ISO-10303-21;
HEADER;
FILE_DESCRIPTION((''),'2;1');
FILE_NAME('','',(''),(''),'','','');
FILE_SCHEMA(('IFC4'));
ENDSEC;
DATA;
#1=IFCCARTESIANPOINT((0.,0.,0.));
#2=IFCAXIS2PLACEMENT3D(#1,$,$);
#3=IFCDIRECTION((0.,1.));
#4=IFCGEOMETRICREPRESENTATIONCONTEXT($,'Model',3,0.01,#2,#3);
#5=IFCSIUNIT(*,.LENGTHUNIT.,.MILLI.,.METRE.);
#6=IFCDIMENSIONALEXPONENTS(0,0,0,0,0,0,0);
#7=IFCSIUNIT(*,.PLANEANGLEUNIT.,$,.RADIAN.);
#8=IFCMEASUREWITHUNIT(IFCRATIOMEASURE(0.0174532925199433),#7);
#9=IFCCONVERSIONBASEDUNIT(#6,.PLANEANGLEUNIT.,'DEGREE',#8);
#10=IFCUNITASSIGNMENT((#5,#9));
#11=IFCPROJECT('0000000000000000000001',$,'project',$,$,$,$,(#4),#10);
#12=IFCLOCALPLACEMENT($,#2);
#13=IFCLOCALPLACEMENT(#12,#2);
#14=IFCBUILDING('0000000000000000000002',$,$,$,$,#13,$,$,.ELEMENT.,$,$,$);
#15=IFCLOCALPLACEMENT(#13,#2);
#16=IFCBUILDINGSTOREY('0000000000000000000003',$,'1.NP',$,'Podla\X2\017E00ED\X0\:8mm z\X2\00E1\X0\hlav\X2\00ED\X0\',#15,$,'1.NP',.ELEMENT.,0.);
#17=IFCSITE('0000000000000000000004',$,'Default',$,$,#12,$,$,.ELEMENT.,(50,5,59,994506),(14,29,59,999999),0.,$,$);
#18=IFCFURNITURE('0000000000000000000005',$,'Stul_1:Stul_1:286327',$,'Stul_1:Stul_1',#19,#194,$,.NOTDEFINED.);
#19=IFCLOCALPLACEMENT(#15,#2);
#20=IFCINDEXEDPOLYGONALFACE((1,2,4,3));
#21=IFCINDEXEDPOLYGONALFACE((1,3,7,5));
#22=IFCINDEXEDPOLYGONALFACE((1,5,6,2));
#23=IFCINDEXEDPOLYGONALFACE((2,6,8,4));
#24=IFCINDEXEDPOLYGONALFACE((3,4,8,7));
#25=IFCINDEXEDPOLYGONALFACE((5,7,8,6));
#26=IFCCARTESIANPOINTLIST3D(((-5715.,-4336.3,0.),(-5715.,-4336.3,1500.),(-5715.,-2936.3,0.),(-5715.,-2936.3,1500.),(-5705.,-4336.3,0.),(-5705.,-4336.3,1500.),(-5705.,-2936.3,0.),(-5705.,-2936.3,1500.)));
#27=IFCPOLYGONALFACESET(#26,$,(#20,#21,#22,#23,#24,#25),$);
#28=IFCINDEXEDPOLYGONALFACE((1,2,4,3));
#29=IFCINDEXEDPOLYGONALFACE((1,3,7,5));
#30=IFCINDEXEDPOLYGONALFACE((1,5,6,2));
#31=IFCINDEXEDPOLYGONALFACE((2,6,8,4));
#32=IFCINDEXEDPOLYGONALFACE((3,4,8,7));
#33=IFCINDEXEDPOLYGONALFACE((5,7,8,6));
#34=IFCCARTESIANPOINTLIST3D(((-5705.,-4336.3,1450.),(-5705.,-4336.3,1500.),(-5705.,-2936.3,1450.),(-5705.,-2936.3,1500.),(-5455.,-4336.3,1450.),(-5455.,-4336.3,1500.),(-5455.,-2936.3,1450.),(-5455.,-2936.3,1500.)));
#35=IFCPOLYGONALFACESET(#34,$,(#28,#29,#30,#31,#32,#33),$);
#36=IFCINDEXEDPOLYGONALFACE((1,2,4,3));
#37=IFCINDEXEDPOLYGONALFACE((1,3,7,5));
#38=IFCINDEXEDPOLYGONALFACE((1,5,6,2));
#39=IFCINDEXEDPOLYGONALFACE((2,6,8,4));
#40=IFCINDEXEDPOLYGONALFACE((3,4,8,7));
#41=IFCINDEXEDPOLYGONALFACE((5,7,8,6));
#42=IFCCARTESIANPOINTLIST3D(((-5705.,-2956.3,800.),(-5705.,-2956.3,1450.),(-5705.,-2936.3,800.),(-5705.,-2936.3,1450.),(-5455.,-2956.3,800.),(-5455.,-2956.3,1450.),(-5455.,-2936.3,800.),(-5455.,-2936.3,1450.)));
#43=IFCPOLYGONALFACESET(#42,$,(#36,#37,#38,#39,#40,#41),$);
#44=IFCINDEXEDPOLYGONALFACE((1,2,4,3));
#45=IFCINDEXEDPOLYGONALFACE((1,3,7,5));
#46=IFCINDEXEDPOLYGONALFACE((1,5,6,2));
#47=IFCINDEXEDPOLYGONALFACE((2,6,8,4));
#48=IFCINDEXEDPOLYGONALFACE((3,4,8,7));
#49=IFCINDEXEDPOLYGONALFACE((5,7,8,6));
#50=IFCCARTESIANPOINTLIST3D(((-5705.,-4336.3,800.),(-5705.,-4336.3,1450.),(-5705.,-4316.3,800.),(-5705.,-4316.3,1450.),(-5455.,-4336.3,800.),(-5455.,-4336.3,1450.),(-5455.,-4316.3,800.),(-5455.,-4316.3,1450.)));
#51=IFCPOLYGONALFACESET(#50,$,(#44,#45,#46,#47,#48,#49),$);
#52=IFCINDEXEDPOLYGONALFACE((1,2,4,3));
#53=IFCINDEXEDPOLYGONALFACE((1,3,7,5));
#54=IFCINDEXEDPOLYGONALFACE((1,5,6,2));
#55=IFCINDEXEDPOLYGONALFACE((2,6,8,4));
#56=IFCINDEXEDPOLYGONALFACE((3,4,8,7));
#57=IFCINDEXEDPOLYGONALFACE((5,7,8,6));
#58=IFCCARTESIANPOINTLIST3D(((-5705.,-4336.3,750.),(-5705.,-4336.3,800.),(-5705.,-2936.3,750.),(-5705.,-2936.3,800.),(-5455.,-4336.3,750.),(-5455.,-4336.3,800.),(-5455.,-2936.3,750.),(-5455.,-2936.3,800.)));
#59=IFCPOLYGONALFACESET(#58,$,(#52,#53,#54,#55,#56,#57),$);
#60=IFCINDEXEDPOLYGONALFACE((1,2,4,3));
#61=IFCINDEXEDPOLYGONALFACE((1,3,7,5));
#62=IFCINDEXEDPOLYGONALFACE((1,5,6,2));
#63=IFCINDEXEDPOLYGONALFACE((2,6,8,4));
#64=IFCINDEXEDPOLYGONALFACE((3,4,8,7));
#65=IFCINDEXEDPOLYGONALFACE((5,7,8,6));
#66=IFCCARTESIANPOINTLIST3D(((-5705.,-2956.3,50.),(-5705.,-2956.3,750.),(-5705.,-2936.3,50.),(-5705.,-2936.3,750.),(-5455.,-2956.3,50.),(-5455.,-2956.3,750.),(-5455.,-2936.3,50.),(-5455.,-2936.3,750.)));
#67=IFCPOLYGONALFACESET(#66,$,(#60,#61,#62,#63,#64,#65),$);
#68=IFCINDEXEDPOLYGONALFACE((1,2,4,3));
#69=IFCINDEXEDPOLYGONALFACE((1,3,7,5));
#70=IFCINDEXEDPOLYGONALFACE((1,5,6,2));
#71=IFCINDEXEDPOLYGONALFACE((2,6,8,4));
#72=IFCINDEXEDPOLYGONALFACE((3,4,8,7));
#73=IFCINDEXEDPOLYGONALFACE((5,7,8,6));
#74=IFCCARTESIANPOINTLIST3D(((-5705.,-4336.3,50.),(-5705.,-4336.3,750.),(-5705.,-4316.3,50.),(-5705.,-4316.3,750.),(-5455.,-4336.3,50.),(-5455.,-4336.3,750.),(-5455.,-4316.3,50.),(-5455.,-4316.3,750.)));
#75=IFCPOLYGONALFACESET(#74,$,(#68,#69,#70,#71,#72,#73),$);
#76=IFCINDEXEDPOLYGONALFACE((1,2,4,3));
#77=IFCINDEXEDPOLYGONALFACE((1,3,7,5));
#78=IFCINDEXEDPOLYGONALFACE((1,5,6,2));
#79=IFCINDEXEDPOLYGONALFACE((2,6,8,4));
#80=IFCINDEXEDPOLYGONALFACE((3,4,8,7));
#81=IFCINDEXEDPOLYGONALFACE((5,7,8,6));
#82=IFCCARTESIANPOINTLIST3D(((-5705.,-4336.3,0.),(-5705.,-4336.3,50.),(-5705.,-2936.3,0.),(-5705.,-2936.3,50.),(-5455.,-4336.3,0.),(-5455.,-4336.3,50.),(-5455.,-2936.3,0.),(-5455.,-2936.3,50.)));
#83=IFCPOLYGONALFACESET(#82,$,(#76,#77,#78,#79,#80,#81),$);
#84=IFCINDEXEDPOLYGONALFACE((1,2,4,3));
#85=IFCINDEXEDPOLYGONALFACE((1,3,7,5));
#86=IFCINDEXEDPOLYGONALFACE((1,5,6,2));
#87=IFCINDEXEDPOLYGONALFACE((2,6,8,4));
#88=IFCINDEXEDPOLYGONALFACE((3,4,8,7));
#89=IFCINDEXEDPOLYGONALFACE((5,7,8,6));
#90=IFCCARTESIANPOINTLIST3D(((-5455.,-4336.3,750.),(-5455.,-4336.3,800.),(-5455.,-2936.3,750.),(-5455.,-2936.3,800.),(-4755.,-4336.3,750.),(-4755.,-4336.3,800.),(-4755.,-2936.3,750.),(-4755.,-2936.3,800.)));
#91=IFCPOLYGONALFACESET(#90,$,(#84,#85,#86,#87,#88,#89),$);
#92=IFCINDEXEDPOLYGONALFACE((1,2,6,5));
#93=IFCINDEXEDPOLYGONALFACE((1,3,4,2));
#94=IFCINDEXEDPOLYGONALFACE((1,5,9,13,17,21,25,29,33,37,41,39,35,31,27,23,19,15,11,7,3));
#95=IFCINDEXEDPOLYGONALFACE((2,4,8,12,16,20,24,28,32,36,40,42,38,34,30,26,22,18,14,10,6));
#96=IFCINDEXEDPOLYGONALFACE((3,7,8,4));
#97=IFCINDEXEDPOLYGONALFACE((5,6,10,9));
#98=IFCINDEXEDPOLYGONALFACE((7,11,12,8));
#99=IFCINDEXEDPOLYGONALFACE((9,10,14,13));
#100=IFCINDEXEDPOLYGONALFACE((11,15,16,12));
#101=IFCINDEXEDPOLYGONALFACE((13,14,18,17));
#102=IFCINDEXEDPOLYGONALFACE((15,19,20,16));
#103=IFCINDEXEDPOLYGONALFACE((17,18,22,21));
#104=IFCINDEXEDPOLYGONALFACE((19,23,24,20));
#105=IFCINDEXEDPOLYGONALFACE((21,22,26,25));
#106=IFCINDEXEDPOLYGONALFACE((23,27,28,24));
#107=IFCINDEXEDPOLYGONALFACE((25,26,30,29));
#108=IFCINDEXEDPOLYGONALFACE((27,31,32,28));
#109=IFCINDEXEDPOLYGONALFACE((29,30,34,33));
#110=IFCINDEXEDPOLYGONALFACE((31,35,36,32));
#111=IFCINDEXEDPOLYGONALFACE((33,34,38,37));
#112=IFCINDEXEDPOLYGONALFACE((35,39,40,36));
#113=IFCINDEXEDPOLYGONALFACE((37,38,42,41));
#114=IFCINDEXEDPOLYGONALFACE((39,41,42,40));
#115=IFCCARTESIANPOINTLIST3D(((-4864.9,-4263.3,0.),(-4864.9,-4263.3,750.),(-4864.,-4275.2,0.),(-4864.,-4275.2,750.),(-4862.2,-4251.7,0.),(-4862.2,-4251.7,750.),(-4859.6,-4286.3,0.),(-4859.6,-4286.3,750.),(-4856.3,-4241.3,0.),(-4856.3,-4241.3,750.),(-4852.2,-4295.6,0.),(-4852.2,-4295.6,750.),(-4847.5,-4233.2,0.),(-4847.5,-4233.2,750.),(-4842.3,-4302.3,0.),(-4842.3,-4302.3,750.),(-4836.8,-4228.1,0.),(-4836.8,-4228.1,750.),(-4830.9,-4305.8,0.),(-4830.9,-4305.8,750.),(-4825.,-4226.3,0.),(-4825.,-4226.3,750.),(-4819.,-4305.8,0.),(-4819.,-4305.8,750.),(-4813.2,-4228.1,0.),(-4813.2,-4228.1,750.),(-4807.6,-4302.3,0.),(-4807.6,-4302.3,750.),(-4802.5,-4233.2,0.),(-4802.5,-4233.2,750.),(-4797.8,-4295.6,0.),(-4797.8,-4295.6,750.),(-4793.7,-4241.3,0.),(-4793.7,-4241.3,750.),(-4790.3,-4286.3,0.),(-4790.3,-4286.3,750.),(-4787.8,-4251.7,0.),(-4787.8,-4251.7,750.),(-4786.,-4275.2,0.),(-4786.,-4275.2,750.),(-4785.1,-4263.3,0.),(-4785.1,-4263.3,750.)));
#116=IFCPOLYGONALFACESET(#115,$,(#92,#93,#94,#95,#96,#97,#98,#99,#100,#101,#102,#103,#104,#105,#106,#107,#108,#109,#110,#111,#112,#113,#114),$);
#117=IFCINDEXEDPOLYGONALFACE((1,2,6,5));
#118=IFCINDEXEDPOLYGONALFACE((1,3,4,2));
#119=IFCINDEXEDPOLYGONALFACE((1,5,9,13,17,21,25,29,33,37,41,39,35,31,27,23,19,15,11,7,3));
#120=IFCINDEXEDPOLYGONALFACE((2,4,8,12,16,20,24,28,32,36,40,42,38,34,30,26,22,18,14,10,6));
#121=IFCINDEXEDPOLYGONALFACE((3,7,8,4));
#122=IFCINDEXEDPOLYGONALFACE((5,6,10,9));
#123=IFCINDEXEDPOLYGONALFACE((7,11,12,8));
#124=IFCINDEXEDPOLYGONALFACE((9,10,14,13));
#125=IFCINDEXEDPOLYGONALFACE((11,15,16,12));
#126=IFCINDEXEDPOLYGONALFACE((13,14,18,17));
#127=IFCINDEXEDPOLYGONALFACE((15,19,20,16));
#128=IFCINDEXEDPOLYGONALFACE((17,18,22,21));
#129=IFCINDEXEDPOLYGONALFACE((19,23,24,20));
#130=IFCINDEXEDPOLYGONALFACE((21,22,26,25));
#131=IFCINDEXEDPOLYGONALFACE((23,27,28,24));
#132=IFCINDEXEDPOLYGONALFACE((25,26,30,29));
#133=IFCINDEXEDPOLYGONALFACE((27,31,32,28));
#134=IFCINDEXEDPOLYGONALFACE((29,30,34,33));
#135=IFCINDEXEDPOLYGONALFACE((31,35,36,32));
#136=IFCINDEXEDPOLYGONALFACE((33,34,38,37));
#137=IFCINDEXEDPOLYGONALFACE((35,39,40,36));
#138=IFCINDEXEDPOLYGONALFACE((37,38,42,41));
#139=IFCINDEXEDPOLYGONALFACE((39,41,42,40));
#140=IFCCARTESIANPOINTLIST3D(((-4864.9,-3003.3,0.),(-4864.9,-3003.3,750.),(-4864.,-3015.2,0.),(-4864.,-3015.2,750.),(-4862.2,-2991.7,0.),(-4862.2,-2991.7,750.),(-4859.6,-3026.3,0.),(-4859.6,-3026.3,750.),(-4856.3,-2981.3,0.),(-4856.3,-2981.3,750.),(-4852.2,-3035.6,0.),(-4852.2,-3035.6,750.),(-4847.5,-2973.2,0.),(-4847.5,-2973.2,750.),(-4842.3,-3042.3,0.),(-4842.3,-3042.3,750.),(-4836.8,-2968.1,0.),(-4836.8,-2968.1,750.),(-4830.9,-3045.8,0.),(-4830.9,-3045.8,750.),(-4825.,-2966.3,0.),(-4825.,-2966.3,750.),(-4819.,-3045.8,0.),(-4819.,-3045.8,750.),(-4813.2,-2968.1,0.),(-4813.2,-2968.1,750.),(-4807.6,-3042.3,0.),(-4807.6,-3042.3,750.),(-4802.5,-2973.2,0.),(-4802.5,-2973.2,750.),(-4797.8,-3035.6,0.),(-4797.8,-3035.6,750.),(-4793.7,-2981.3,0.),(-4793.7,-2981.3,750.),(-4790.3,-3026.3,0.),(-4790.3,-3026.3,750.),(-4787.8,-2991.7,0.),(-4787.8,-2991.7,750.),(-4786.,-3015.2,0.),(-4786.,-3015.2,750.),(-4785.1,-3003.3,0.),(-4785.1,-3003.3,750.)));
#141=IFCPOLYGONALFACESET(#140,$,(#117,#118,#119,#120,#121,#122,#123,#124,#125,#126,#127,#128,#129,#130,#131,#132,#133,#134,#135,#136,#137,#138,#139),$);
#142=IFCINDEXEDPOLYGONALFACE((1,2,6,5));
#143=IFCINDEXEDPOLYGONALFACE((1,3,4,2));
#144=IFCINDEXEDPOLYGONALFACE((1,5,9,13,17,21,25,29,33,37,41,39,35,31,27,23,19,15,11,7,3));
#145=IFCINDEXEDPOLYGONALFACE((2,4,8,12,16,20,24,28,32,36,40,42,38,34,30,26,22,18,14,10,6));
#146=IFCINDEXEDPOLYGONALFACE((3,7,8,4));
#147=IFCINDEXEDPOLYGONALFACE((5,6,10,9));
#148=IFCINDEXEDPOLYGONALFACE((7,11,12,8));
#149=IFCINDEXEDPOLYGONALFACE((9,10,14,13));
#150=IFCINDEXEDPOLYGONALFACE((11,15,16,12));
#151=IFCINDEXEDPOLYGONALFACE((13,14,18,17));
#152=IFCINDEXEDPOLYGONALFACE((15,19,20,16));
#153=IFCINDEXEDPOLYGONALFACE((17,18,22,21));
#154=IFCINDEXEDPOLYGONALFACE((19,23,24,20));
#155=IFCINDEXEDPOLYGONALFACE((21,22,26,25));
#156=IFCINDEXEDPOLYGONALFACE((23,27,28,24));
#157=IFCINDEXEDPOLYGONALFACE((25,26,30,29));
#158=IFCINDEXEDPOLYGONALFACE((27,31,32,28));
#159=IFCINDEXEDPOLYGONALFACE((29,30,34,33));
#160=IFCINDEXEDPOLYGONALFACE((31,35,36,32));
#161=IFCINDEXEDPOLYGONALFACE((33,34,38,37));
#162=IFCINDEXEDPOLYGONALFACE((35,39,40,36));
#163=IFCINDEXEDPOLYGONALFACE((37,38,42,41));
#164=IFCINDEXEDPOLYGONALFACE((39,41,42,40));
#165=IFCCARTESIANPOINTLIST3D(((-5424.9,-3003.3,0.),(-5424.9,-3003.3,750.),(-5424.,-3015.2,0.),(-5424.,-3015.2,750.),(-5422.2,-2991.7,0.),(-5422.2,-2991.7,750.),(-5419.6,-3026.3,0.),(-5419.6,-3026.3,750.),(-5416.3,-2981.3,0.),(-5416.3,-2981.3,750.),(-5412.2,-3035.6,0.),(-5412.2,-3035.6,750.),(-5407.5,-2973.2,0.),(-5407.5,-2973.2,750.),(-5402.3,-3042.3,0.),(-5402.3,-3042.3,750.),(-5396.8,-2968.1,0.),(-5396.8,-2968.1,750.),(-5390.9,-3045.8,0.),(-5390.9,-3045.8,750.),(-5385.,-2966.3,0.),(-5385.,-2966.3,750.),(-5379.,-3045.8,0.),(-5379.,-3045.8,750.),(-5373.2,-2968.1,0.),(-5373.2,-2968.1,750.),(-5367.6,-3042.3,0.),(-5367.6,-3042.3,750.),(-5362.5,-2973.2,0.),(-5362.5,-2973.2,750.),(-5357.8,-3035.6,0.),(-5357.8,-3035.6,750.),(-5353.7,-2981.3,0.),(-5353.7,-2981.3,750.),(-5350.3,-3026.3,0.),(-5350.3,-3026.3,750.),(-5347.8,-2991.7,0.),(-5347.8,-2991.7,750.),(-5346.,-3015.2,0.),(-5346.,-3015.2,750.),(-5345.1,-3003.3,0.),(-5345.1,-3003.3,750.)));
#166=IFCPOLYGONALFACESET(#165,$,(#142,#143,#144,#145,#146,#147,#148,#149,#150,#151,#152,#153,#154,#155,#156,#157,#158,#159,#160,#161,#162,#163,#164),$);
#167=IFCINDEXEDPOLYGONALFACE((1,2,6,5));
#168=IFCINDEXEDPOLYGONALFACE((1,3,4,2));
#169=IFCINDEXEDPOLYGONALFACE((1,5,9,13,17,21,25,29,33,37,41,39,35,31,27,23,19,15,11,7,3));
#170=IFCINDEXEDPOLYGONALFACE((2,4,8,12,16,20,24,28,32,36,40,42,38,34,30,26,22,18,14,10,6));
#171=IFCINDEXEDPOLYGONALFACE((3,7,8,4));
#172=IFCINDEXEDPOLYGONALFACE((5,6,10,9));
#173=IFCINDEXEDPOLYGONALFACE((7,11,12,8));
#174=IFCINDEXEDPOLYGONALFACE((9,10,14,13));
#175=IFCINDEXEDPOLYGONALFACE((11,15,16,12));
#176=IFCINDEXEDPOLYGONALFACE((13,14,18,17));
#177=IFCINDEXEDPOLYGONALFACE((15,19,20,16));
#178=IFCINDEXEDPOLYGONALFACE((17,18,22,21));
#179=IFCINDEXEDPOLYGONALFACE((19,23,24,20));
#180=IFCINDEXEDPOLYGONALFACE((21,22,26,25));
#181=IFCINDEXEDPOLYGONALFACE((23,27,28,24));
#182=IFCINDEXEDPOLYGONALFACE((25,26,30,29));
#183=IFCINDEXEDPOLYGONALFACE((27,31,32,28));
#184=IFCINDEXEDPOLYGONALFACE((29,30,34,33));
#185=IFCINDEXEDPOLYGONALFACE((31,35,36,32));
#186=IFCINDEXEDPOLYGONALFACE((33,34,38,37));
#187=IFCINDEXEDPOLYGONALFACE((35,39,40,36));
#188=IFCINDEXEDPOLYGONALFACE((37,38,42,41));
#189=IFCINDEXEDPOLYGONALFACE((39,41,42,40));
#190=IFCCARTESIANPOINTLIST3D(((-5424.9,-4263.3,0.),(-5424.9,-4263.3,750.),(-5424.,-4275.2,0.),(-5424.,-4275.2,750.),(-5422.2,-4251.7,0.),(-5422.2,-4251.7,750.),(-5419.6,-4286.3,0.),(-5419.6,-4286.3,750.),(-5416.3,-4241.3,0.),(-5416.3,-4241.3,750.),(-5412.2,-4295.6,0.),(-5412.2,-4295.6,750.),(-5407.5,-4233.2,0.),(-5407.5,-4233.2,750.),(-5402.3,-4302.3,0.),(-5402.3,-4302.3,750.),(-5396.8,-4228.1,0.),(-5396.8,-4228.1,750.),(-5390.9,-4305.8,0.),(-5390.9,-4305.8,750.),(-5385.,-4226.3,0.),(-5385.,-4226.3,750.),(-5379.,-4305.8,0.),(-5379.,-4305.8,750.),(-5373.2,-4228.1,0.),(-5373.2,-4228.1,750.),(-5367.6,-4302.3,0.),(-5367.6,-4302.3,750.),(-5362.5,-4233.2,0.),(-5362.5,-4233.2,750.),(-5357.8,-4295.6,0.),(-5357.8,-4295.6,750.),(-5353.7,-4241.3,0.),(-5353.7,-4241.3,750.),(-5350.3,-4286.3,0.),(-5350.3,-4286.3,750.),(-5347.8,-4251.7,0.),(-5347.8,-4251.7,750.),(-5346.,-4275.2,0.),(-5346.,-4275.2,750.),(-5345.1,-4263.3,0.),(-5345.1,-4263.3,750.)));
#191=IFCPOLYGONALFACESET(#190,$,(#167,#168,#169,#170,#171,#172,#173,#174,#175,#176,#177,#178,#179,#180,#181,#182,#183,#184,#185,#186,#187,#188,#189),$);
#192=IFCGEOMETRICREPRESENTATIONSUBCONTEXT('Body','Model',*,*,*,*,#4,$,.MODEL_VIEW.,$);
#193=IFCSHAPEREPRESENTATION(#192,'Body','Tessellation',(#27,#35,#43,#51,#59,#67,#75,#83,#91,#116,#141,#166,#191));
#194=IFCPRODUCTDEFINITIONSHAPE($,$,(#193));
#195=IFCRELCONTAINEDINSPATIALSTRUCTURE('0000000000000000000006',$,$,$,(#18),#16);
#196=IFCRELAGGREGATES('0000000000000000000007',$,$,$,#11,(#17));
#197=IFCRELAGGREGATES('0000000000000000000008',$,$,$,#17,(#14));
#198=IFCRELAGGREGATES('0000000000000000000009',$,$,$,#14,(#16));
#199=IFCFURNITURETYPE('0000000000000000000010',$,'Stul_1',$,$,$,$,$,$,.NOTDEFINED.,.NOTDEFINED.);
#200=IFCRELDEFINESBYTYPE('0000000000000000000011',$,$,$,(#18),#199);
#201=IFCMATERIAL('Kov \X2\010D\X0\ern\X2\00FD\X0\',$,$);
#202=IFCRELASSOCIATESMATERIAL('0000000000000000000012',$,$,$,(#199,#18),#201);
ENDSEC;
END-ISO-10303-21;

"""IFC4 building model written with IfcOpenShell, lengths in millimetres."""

from ifc_helpers import new_model, entity, si_unit, converted_unit, direction, frame, frame_2d, origin, origin_2d_with_axis, place, context, subcontext, project, spatial, rectangle, circle, extrude, source, transform, mapped, material, type_object, type_shapes, element, save


model = new_model("IFC4")

# Units and contexts
model_context = context("Model", 3, precision=0.01, world=origin(), true_north=direction((0.0, 1.0)))
body_context = subcontext(model_context, "Body", "Model", "MODEL_VIEW")
ifc_project = project(units=[si_unit("LENGTHUNIT", "METRE", prefix="MILLI"), converted_unit("PLANEANGLEUNIT", "DEGREE", entity("IfcRatioMeasure", 0.0174532925199433), si_unit("PLANEANGLEUNIT", "RADIAN"), dimensions=[0, 0, 0, 0, 0, 0, 0])], contexts=[model_context])

# Site, building, storey
site_placement = place(None, origin())
site = spatial("IfcSite", under=ifc_project, at=site_placement, Name="Default", CompositionType="ELEMENT", RefLatitude=(50, 5, 59, 994506), RefLongitude=(14, 29, 59, 999999), RefElevation=0.0)
building_placement = place(site_placement, origin())
building = spatial("IfcBuilding", under=site, at=building_placement, CompositionType="ELEMENT")
storey_placement = place(building_placement, origin())
storey = spatial("IfcBuildingStorey", under=building, at=storey_placement, Name="1.NP", ObjectType="Podlaží:8mm záhlaví", LongName="1.NP", CompositionType="ELEMENT", Elevation=0.0)

# Furniture
ifc_material_1 = material(Name="Kov černý")
furniture_type = type_object("IfcFurnitureType", Name="Stul_1", AssemblyPlace="NOTDEFINED", PredefinedType="NOTDEFINED", material=ifc_material_1)
shared_shape_1 = source(origin(), body_context, "Body", "SweptSolid", [
    extrude(rectangle(XDim=1400.0, YDim=10.0, at=origin_2d_with_axis()), frame((0.0, 605.0, 0.0), z_axis=(0.0, 0.0, 1.0), x_axis=(-1.0, 0.0, 0.0)), (0.0, 0.0, 1.0), 1500.0),
    extrude(rectangle(XDim=1400.0, YDim=250.0, at=frame_2d((0.0, 0.0), x_axis=(1.0, 0.0))), frame((0.0, 475.0, 1450.0), z_axis=(0.0, 0.0, 1.0), x_axis=(-1.0, 0.0, 0.0)), (0.0, 0.0, 1.0), 50.0),
    extrude(rectangle(XDim=20.0, YDim=250.0, at=origin_2d_with_axis()), frame((690.0, 475.0, 800.0), z_axis=(0.0, 0.0, 1.0), x_axis=(-1.0, 0.0, 0.0)), (0.0, 0.0, 1.0), 650.0),
    extrude(rectangle(XDim=20.0, YDim=250.0, at=frame_2d((0.0, 0.0), x_axis=(1.0, 0.0))), frame((-690.0, 475.0, 800.0), z_axis=(0.0, 0.0, 1.0), x_axis=(-1.0, 0.0, 0.0)), (0.0, 0.0, 1.0), 650.0),
    extrude(rectangle(XDim=1400.0, YDim=250.0, at=origin_2d_with_axis()), frame((0.0, 475.0, 750.0), z_axis=(0.0, 0.0, 1.0), x_axis=(-1.0, 0.0, 0.0)), (0.0, 0.0, 1.0), 50.0),
    extrude(rectangle(XDim=20.0, YDim=250.0, at=origin_2d_with_axis()), frame((690.0, 475.0, 50.0), z_axis=(0.0, 0.0, 1.0), x_axis=(-1.0, 0.0, 0.0)), (0.0, 0.0, 1.0), 700.0),
    extrude(rectangle(XDim=20.0, YDim=250.0, at=frame_2d((0.0, 0.0), x_axis=(1.0, 0.0))), frame((-690.0, 475.0, 50.0), z_axis=(0.0, 0.0, 1.0), x_axis=(-1.0, 0.0, 0.0)), (0.0, 0.0, 1.0), 700.0),
    extrude(rectangle(XDim=1400.0, YDim=250.0, at=origin_2d_with_axis()), frame((0.0, 475.0, 0.0), z_axis=(0.0, 0.0, 1.0), x_axis=(-1.0, 0.0, 0.0)), (0.0, 0.0, 1.0), 50.0),
    extrude(rectangle(XDim=1400.0, YDim=700.0, at=origin_2d_with_axis()), frame((0.0, 0.0, 750.0), z_axis=(0.0, 0.0, 1.0), x_axis=(-1.0, 0.0, 0.0)), (0.0, 0.0, 1.0), 50.0),
    extrude(circle(Radius=40.0, at=frame_2d((0.0, 0.0), x_axis=(1.0, 0.0))), frame((-630.0, -280.0, 0.0)), (0.0, 0.0, 1.0), 750.0),
    extrude(circle(Radius=40.0, at=frame_2d((0.0, 0.0), x_axis=(1.0, 0.0))), frame((630.0, -280.0, 0.0)), (0.0, 0.0, 1.0), 750.0),
    extrude(circle(Radius=40.0, at=frame_2d((0.0, 0.0), x_axis=(1.0, 0.0))), frame((630.0, 280.0, 0.0)), (0.0, 0.0, 1.0), 750.0),
    extrude(circle(Radius=40.0, at=frame_2d((0.0, 0.0), x_axis=(1.0, 0.0))), frame((-630.0, 280.0, 0.0)), (0.0, 0.0, 1.0), 750.0),
])
type_shapes(furniture_type, [shared_shape_1])
for number, where, z_axis, x_axis, name in (
    (1, (-5105.0, -3636.3, 0.0), (0.0, 0.0, 1.0), (0.0, 1.0, 0.0), "Stul_1:Stul_1:286327"),
):
    element("IfcFurniture", number, at=place(storey_placement, frame(where, z_axis=z_axis, x_axis=x_axis)), inside=storey, type_object=furniture_type, material=ifc_material_1, Name=name, ObjectType="Stul_1:Stul_1", PredefinedType="NOTDEFINED", context=body_context, shape_type="MappedRepresentation", body=[
        mapped(shared_shape_1, transform((0.0, 0.0, 0.0), scale=1.0)),
    ])

save(model, "model.ifc")
